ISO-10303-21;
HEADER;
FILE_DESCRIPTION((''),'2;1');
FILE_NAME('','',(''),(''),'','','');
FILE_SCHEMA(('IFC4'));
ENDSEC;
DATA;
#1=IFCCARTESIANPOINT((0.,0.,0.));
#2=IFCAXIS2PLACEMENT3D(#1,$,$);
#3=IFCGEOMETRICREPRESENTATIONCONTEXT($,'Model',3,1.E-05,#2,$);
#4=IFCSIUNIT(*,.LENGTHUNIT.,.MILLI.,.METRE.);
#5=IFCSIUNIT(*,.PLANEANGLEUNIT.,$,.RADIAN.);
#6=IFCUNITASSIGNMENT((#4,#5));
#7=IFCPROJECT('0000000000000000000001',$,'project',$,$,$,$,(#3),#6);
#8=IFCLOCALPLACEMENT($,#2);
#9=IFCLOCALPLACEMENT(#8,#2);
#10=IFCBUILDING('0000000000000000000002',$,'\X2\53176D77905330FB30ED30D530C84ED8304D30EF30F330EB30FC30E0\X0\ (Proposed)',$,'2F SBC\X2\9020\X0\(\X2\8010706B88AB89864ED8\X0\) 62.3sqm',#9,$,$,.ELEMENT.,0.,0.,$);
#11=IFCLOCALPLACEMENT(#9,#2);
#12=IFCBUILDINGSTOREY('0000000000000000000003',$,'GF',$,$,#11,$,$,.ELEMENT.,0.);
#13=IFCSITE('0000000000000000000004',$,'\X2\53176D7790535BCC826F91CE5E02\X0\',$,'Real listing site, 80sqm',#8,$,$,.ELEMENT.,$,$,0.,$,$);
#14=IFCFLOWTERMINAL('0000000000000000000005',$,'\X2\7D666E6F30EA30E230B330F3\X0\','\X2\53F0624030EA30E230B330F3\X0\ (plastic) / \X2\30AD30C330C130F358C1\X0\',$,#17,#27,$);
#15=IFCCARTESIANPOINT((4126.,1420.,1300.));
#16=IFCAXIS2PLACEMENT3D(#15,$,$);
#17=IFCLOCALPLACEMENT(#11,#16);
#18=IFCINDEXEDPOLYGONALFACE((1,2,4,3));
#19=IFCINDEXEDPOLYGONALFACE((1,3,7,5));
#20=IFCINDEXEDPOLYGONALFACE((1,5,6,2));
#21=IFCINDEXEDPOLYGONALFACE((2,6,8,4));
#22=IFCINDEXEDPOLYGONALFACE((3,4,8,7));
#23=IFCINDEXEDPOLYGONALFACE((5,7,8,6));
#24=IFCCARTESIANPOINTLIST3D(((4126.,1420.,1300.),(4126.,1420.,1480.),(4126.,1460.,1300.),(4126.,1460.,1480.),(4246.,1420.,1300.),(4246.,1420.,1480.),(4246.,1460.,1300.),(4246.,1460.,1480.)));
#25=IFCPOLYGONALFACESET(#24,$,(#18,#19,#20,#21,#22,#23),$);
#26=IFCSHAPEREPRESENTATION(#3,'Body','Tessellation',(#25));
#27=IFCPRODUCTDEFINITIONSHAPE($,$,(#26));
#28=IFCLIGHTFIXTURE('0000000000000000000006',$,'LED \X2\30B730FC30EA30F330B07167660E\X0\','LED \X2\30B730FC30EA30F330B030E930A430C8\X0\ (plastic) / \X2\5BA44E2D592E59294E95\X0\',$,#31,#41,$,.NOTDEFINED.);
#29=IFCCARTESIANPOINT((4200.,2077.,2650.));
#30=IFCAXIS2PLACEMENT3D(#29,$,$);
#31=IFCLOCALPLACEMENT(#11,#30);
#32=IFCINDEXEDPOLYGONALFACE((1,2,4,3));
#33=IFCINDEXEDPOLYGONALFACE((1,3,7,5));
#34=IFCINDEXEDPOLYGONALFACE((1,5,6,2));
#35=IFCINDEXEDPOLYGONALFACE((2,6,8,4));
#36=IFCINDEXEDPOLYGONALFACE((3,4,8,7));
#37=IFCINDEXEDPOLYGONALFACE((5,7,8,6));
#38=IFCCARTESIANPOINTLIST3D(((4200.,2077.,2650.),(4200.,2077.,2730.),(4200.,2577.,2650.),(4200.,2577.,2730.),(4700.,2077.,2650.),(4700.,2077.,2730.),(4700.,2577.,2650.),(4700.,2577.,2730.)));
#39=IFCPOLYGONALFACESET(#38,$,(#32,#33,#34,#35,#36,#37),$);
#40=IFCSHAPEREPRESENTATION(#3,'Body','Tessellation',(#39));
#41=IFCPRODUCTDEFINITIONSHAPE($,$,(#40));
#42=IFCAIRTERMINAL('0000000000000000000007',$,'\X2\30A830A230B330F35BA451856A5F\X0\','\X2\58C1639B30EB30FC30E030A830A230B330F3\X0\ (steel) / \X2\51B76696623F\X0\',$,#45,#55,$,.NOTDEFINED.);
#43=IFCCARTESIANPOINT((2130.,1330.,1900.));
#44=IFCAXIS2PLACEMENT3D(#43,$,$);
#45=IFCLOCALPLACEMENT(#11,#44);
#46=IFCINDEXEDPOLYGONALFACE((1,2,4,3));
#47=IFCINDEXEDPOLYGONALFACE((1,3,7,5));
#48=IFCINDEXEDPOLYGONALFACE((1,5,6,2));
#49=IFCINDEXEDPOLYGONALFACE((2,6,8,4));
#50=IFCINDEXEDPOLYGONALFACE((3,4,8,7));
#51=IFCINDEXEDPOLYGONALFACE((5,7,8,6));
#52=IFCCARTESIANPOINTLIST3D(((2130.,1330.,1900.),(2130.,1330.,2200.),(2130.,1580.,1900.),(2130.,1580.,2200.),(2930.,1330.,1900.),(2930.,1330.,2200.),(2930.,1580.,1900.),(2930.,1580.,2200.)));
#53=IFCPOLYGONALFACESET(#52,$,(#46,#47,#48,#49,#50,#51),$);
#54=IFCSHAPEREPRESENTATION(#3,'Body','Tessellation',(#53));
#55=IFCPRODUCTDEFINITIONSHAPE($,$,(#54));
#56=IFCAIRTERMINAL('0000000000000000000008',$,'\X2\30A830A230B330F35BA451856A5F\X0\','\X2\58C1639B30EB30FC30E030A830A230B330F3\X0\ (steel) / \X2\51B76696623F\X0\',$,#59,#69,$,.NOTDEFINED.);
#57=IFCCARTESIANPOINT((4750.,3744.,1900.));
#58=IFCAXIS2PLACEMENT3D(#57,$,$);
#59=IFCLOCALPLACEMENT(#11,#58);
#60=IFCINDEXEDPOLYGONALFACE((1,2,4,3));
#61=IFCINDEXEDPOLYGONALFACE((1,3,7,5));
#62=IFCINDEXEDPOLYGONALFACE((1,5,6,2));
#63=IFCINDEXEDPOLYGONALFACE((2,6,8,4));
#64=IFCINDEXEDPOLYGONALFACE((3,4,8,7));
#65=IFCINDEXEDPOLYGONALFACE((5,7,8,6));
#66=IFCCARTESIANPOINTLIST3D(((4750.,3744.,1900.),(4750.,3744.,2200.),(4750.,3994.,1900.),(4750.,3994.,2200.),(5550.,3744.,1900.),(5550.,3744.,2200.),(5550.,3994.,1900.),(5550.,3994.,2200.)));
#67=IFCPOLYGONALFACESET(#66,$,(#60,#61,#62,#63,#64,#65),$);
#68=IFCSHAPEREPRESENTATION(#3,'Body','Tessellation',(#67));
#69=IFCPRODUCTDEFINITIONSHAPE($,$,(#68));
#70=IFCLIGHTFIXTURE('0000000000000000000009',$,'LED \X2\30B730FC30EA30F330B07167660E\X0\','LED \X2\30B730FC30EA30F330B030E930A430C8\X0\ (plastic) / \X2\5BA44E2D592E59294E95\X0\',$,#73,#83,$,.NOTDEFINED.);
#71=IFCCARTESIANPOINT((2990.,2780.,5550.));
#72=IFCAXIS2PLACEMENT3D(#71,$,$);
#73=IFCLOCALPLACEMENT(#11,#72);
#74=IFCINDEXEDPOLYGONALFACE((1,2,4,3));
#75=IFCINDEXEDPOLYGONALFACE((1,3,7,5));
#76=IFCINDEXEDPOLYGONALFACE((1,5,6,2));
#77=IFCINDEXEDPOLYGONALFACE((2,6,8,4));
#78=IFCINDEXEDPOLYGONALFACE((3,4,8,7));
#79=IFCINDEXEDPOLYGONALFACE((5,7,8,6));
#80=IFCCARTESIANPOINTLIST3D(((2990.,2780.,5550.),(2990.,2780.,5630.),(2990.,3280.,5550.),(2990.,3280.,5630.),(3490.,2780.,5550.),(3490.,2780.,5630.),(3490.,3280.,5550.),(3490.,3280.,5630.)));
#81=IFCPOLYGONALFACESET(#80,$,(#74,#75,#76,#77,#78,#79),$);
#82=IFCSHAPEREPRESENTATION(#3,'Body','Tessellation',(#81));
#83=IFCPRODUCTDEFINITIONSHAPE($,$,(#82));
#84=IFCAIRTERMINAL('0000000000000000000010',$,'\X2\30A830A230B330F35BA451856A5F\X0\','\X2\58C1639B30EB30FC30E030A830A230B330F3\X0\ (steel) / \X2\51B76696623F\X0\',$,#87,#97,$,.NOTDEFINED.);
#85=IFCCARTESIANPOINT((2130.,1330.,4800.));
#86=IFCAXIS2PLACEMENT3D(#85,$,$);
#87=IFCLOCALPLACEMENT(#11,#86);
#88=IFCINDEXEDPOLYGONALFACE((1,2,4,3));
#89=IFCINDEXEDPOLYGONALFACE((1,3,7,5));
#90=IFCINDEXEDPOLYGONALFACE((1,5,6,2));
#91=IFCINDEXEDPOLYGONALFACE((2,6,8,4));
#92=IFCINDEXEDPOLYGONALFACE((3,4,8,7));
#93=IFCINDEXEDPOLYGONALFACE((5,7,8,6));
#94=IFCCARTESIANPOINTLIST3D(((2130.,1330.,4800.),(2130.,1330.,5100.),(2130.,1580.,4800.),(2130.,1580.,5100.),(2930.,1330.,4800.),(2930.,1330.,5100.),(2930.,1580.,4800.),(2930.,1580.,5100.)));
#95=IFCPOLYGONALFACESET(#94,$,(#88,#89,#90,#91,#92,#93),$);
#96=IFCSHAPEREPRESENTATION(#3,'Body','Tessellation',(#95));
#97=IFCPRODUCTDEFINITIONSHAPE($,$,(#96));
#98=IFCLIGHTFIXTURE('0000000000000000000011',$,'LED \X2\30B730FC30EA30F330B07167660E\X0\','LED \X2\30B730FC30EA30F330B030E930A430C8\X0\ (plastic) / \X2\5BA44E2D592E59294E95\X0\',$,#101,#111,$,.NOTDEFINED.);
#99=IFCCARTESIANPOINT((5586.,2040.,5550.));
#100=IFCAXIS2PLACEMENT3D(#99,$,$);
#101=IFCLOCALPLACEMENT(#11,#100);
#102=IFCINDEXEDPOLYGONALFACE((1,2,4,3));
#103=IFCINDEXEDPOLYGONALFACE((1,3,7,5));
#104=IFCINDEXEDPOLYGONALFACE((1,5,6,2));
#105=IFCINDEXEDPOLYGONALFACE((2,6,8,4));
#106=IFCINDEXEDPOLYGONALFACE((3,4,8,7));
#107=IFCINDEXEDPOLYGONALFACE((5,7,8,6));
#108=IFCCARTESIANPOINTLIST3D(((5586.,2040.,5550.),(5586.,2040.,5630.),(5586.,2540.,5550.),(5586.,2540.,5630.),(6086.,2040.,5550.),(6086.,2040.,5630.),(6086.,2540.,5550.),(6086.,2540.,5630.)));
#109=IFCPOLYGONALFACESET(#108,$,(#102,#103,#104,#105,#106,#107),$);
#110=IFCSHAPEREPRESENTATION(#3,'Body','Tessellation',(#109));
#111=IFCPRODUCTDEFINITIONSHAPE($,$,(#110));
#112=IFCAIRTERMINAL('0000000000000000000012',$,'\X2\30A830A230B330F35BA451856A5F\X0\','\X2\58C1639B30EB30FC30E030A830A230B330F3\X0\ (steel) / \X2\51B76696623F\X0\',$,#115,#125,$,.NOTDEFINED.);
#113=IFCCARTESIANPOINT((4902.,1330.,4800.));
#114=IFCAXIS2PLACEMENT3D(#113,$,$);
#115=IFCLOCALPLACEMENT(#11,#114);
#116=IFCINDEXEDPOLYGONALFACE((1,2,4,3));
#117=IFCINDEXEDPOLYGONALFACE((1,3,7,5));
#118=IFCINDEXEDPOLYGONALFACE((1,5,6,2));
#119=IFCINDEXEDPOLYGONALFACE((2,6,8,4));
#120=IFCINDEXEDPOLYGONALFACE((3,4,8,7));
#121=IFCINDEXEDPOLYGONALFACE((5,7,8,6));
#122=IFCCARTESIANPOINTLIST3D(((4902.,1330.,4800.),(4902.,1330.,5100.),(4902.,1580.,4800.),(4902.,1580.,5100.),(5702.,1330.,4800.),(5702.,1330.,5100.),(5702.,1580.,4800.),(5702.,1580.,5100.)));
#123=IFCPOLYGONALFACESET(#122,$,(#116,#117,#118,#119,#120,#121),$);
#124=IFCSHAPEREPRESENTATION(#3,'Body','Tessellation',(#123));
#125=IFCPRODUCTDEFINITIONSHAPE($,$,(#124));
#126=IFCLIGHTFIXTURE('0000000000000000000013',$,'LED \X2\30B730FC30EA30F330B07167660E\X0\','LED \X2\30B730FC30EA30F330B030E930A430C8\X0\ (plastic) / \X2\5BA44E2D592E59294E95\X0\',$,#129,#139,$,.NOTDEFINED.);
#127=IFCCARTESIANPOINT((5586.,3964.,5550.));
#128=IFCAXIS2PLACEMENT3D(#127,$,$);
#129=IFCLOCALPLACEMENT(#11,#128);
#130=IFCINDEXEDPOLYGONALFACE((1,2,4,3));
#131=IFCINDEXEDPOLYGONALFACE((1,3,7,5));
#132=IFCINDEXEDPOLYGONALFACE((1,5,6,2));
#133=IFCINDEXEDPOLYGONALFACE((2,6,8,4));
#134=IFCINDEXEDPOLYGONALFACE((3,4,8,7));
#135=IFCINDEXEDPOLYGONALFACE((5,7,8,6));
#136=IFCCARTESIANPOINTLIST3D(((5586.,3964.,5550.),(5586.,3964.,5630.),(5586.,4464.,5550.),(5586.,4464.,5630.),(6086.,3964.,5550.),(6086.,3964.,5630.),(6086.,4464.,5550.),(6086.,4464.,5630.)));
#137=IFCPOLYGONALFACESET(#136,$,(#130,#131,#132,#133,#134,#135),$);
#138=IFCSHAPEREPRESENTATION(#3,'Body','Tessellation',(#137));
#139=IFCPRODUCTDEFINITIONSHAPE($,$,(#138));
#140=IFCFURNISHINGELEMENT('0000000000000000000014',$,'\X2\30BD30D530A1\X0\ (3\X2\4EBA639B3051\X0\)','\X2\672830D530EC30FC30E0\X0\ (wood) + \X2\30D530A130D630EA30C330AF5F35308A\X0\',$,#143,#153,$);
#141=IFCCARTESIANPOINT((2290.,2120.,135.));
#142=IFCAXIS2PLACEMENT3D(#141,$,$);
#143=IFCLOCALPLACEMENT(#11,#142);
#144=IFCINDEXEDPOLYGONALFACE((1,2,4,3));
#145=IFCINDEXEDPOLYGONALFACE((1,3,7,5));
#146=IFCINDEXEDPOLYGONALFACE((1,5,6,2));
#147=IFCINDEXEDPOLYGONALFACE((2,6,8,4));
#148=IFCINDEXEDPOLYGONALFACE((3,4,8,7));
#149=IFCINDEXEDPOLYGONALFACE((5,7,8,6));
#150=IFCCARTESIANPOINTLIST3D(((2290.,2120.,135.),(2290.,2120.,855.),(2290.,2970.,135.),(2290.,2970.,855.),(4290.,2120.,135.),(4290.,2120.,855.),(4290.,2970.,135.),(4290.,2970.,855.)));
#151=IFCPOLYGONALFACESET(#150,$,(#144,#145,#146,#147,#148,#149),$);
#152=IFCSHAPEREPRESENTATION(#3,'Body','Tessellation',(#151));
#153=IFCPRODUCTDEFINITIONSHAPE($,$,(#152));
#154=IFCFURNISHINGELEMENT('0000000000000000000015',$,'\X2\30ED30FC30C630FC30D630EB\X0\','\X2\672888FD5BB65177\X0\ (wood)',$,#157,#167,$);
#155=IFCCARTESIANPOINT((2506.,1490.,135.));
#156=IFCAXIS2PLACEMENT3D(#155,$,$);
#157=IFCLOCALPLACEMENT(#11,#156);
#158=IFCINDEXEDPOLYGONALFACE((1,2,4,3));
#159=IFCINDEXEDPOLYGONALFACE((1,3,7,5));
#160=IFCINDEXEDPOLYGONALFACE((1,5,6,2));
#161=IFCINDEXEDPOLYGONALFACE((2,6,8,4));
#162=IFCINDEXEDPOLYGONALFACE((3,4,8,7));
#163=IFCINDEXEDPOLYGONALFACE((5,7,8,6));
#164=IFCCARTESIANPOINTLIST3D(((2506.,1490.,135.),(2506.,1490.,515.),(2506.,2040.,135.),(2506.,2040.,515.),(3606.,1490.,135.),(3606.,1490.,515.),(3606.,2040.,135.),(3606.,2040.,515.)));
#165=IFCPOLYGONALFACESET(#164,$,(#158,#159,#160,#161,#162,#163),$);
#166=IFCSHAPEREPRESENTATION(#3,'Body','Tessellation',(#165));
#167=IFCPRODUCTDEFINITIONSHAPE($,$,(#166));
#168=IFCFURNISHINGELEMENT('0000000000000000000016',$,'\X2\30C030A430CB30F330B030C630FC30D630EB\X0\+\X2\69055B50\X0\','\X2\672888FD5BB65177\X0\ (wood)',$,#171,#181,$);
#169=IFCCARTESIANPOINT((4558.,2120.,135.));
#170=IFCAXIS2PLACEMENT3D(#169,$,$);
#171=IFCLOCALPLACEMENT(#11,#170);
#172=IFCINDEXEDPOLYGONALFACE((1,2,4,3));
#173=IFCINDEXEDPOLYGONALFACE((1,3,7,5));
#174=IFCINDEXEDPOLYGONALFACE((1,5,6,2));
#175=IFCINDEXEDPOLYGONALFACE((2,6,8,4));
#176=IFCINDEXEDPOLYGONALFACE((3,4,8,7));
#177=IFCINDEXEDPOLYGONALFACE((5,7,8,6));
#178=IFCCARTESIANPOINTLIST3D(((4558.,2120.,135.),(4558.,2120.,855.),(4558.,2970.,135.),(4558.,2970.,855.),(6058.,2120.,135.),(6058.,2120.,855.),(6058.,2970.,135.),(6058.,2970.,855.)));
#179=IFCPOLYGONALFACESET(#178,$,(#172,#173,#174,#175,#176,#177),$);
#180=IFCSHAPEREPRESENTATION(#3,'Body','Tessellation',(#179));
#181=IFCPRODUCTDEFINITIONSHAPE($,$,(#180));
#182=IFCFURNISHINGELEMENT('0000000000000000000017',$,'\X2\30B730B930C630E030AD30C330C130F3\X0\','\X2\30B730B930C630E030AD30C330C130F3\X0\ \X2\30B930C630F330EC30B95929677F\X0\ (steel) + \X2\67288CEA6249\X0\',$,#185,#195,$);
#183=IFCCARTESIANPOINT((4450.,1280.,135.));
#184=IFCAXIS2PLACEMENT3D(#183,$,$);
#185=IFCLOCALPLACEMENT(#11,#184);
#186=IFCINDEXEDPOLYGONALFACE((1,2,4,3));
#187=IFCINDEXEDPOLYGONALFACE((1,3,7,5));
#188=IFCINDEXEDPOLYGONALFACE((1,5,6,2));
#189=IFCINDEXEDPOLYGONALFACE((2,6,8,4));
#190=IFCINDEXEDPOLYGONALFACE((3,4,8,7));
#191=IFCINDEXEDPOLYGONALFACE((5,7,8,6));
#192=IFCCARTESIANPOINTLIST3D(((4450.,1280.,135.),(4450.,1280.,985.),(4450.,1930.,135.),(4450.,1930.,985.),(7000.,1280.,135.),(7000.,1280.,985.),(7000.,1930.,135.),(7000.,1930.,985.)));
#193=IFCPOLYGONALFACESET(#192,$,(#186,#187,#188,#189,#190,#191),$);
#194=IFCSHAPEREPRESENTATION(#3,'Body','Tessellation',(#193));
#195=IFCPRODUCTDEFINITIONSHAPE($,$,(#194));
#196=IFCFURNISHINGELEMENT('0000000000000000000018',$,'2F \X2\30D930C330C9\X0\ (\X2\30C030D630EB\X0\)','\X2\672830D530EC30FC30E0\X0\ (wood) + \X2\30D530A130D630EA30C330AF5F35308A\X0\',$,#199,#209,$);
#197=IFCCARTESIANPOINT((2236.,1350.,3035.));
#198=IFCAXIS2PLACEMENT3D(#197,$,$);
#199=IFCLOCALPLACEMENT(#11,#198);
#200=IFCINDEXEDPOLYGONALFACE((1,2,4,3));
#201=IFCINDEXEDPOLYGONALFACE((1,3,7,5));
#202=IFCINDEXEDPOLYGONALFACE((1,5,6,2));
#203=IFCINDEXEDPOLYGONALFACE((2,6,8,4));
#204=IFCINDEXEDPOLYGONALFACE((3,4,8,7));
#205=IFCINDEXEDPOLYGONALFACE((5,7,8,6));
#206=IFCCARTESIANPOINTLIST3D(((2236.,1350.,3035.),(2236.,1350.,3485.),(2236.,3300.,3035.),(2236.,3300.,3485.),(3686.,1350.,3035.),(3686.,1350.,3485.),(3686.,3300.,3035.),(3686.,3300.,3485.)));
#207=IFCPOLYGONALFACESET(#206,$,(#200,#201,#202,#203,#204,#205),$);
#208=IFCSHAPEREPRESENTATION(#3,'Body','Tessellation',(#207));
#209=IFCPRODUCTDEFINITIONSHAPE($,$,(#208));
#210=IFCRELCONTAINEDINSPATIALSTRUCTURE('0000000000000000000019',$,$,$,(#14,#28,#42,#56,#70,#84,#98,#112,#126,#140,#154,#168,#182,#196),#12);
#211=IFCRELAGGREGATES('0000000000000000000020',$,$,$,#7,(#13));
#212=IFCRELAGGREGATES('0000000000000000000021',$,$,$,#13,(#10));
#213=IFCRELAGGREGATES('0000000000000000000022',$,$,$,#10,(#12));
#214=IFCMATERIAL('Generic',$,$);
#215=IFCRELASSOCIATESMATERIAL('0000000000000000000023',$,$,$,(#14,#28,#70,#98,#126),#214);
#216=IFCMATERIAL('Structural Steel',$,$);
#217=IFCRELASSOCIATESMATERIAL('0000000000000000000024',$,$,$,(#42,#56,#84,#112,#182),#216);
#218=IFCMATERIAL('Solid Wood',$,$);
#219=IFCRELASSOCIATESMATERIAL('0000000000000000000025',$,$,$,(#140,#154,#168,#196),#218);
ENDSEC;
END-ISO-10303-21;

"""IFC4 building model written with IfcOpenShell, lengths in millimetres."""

from ifc_helpers import new_model, si_unit, frame, frame_2d, origin, place, context, project, spatial, rectangle, extrude, material, element, save


model = new_model("IFC4")

# Units and contexts
model_context = context("Model", 3, precision=1e-05, world=origin())
ifc_project = project(units=[si_unit("LENGTHUNIT", "METRE", prefix="MILLI"), si_unit("PLANEANGLEUNIT", "RADIAN")], contexts=[model_context])

# Site, building, storey
site_placement = place(None, origin())
site = spatial("IfcSite", under=ifc_project, at=site_placement, Name="北海道富良野市", ObjectType="Real listing site, 80sqm", CompositionType="ELEMENT", RefElevation=0.0)
building_placement = place(site_placement, origin())
building = spatial("IfcBuilding", under=site, at=building_placement, Name="北海道・ロフト付きワンルーム (Proposed)", ObjectType="2F SBC造(耐火被覆付) 62.3sqm", CompositionType="ELEMENT", ElevationOfRefHeight=0.0, ElevationOfTerrain=0.0)
storey_placement = place(building_placement, origin())
storey = spatial("IfcBuildingStorey", under=building, at=storey_placement, Name="GF", CompositionType="ELEMENT", Elevation=0.0)

# Shared definitions
ifc_material_1 = material(Name="Solid Wood")

# Shared definitions
ifc_material_2 = material(Name="Structural Steel")

# Flow terminal
ifc_material_3 = material(Name="Generic")
flow_terminal_1_placement = place(storey_placement, frame((4126.0, 1420.0, 1300.0)))
element("IfcFlowTerminal", 1, at=flow_terminal_1_placement, inside=storey, material=ifc_material_3, Name="給湯リモコン", Description="台所リモコン (plastic) / キッチン壁", context=model_context, shape_type="SweptSolid", body=[
    extrude(rectangle(XDim=120.0, YDim=40.0, at=frame_2d((60.0, 20.0))), frame((4126.0, 1420.0, 1300.0)), (0.0, 0.0, 1.0), 180.0),
])

# Light fixture
light_fixture_1_placement = place(storey_placement, frame((4200.0, 2077.0, 2650.0)))
element("IfcLightFixture", 2, at=light_fixture_1_placement, inside=storey, material=ifc_material_3, Name="LED シーリング照明", Description="LED シーリングライト (plastic) / 室中央天井", PredefinedType="NOTDEFINED", context=model_context, shape_type="SweptSolid", body=[
    extrude(rectangle(XDim=500.0, YDim=500.0, at=frame_2d((250.0, 250.0))), frame((4200.0, 2077.0, 2650.0)), (0.0, 0.0, 1.0), 80.0),
])

# Air terminals
air_terminal_1_placement = place(storey_placement, frame((2130.0, 1330.0, 1900.0)))
element("IfcAirTerminal", 3, at=air_terminal_1_placement, inside=storey, material=ifc_material_2, Name="エアコン室内機", Description="壁掛ルームエアコン (steel) / 冷暖房", PredefinedType="NOTDEFINED", context=model_context, shape_type="SweptSolid", body=[
    extrude(rectangle(XDim=800.0, YDim=250.0, at=frame_2d((400.0, 125.0))), frame((2130.0, 1330.0, 1900.0)), (0.0, 0.0, 1.0), 300.0),
])
air_terminal_2_placement = place(storey_placement, frame((4750.0, 3744.0, 1900.0)))
element("IfcAirTerminal", 4, at=air_terminal_2_placement, inside=storey, material=ifc_material_2, Name="エアコン室内機", Description="壁掛ルームエアコン (steel) / 冷暖房", PredefinedType="NOTDEFINED", context=model_context, shape_type="SweptSolid", body=[
    extrude(rectangle(XDim=800.0, YDim=250.0, at=frame_2d((400.0, 125.0))), frame((4750.0, 3744.0, 1900.0)), (0.0, 0.0, 1.0), 300.0),
])

# Light fixture
light_fixture_2_placement = place(storey_placement, frame((2990.0, 2780.0, 5550.0)))
element("IfcLightFixture", 5, at=light_fixture_2_placement, inside=storey, material=ifc_material_3, Name="LED シーリング照明", Description="LED シーリングライト (plastic) / 室中央天井", PredefinedType="NOTDEFINED", context=model_context, shape_type="SweptSolid", body=[
    extrude(rectangle(XDim=500.0, YDim=500.0, at=frame_2d((250.0, 250.0))), frame((2990.0, 2780.0, 5550.0)), (0.0, 0.0, 1.0), 80.0),
])

# Air terminal
air_terminal_3_placement = place(storey_placement, frame((2130.0, 1330.0, 4800.0)))
element("IfcAirTerminal", 6, at=air_terminal_3_placement, inside=storey, material=ifc_material_2, Name="エアコン室内機", Description="壁掛ルームエアコン (steel) / 冷暖房", PredefinedType="NOTDEFINED", context=model_context, shape_type="SweptSolid", body=[
    extrude(rectangle(XDim=800.0, YDim=250.0, at=frame_2d((400.0, 125.0))), frame((2130.0, 1330.0, 4800.0)), (0.0, 0.0, 1.0), 300.0),
])

# Light fixture
light_fixture_3_placement = place(storey_placement, frame((5586.0, 2040.0, 5550.0)))
element("IfcLightFixture", 7, at=light_fixture_3_placement, inside=storey, material=ifc_material_3, Name="LED シーリング照明", Description="LED シーリングライト (plastic) / 室中央天井", PredefinedType="NOTDEFINED", context=model_context, shape_type="SweptSolid", body=[
    extrude(rectangle(XDim=500.0, YDim=500.0, at=frame_2d((250.0, 250.0))), frame((5586.0, 2040.0, 5550.0)), (0.0, 0.0, 1.0), 80.0),
])

# Air terminal
air_terminal_4_placement = place(storey_placement, frame((4902.0, 1330.0, 4800.0)))
element("IfcAirTerminal", 8, at=air_terminal_4_placement, inside=storey, material=ifc_material_2, Name="エアコン室内機", Description="壁掛ルームエアコン (steel) / 冷暖房", PredefinedType="NOTDEFINED", context=model_context, shape_type="SweptSolid", body=[
    extrude(rectangle(XDim=800.0, YDim=250.0, at=frame_2d((400.0, 125.0))), frame((4902.0, 1330.0, 4800.0)), (0.0, 0.0, 1.0), 300.0),
])

# Light fixture
light_fixture_4_placement = place(storey_placement, frame((5586.0, 3964.0, 5550.0)))
element("IfcLightFixture", 9, at=light_fixture_4_placement, inside=storey, material=ifc_material_3, Name="LED シーリング照明", Description="LED シーリングライト (plastic) / 室中央天井", PredefinedType="NOTDEFINED", context=model_context, shape_type="SweptSolid", body=[
    extrude(rectangle(XDim=500.0, YDim=500.0, at=frame_2d((250.0, 250.0))), frame((5586.0, 3964.0, 5550.0)), (0.0, 0.0, 1.0), 80.0),
])

# Furnishing elements
furnishing_1_placement = place(storey_placement, frame((2290.0, 2120.0, 135.0)))
element("IfcFurnishingElement", 10, at=furnishing_1_placement, inside=storey, material=ifc_material_1, Name="ソファ (3人掛け)", Description="木フレーム (wood) + ファブリック張り", context=model_context, shape_type="SweptSolid", body=[
    extrude(rectangle(XDim=2000.0, YDim=850.0, at=frame_2d((1000.0, 425.0))), frame((2290.0, 2120.0, 135.0)), (0.0, 0.0, 1.0), 720.0),
])
furnishing_2_placement = place(storey_placement, frame((2506.0, 1490.0, 135.0)))
element("IfcFurnishingElement", 11, at=furnishing_2_placement, inside=storey, material=ifc_material_1, Name="ローテーブル", Description="木製家具 (wood)", context=model_context, shape_type="SweptSolid", body=[
    extrude(rectangle(XDim=1100.0, YDim=550.0, at=frame_2d((550.0, 275.0))), frame((2506.0, 1490.0, 135.0)), (0.0, 0.0, 1.0), 380.0),
])
furnishing_3_placement = place(storey_placement, frame((4558.0, 2120.0, 135.0)))
element("IfcFurnishingElement", 12, at=furnishing_3_placement, inside=storey, material=ifc_material_1, Name="ダイニングテーブル+椅子", Description="木製家具 (wood)", context=model_context, shape_type="SweptSolid", body=[
    extrude(rectangle(XDim=1500.0, YDim=850.0, at=frame_2d((750.0, 425.0))), frame((4558.0, 2120.0, 135.0)), (0.0, 0.0, 1.0), 720.0),
])
furnishing_4_placement = place(storey_placement, frame((4450.0, 1280.0, 135.0)))
element("IfcFurnishingElement", 13, at=furnishing_4_placement, inside=storey, material=ifc_material_2, Name="システムキッチン", Description="システムキッチン ステンレス天板 (steel) + 木質扉", context=model_context, shape_type="SweptSolid", body=[
    extrude(rectangle(XDim=2550.0, YDim=650.0, at=frame_2d((1275.0, 325.0))), frame((4450.0, 1280.0, 135.0)), (0.0, 0.0, 1.0), 850.0),
])
furnishing_5_placement = place(storey_placement, frame((2236.0, 1350.0, 3035.0)))
element("IfcFurnishingElement", 14, at=furnishing_5_placement, inside=storey, material=ifc_material_1, Name="2F ベッド (ダブル)", Description="木フレーム (wood) + ファブリック張り", context=model_context, shape_type="SweptSolid", body=[
    extrude(rectangle(XDim=1450.0, YDim=1950.0, at=frame_2d((725.0, 975.0))), frame((2236.0, 1350.0, 3035.0)), (0.0, 0.0, 1.0), 450.0),
])

save(model, "model.ifc")
